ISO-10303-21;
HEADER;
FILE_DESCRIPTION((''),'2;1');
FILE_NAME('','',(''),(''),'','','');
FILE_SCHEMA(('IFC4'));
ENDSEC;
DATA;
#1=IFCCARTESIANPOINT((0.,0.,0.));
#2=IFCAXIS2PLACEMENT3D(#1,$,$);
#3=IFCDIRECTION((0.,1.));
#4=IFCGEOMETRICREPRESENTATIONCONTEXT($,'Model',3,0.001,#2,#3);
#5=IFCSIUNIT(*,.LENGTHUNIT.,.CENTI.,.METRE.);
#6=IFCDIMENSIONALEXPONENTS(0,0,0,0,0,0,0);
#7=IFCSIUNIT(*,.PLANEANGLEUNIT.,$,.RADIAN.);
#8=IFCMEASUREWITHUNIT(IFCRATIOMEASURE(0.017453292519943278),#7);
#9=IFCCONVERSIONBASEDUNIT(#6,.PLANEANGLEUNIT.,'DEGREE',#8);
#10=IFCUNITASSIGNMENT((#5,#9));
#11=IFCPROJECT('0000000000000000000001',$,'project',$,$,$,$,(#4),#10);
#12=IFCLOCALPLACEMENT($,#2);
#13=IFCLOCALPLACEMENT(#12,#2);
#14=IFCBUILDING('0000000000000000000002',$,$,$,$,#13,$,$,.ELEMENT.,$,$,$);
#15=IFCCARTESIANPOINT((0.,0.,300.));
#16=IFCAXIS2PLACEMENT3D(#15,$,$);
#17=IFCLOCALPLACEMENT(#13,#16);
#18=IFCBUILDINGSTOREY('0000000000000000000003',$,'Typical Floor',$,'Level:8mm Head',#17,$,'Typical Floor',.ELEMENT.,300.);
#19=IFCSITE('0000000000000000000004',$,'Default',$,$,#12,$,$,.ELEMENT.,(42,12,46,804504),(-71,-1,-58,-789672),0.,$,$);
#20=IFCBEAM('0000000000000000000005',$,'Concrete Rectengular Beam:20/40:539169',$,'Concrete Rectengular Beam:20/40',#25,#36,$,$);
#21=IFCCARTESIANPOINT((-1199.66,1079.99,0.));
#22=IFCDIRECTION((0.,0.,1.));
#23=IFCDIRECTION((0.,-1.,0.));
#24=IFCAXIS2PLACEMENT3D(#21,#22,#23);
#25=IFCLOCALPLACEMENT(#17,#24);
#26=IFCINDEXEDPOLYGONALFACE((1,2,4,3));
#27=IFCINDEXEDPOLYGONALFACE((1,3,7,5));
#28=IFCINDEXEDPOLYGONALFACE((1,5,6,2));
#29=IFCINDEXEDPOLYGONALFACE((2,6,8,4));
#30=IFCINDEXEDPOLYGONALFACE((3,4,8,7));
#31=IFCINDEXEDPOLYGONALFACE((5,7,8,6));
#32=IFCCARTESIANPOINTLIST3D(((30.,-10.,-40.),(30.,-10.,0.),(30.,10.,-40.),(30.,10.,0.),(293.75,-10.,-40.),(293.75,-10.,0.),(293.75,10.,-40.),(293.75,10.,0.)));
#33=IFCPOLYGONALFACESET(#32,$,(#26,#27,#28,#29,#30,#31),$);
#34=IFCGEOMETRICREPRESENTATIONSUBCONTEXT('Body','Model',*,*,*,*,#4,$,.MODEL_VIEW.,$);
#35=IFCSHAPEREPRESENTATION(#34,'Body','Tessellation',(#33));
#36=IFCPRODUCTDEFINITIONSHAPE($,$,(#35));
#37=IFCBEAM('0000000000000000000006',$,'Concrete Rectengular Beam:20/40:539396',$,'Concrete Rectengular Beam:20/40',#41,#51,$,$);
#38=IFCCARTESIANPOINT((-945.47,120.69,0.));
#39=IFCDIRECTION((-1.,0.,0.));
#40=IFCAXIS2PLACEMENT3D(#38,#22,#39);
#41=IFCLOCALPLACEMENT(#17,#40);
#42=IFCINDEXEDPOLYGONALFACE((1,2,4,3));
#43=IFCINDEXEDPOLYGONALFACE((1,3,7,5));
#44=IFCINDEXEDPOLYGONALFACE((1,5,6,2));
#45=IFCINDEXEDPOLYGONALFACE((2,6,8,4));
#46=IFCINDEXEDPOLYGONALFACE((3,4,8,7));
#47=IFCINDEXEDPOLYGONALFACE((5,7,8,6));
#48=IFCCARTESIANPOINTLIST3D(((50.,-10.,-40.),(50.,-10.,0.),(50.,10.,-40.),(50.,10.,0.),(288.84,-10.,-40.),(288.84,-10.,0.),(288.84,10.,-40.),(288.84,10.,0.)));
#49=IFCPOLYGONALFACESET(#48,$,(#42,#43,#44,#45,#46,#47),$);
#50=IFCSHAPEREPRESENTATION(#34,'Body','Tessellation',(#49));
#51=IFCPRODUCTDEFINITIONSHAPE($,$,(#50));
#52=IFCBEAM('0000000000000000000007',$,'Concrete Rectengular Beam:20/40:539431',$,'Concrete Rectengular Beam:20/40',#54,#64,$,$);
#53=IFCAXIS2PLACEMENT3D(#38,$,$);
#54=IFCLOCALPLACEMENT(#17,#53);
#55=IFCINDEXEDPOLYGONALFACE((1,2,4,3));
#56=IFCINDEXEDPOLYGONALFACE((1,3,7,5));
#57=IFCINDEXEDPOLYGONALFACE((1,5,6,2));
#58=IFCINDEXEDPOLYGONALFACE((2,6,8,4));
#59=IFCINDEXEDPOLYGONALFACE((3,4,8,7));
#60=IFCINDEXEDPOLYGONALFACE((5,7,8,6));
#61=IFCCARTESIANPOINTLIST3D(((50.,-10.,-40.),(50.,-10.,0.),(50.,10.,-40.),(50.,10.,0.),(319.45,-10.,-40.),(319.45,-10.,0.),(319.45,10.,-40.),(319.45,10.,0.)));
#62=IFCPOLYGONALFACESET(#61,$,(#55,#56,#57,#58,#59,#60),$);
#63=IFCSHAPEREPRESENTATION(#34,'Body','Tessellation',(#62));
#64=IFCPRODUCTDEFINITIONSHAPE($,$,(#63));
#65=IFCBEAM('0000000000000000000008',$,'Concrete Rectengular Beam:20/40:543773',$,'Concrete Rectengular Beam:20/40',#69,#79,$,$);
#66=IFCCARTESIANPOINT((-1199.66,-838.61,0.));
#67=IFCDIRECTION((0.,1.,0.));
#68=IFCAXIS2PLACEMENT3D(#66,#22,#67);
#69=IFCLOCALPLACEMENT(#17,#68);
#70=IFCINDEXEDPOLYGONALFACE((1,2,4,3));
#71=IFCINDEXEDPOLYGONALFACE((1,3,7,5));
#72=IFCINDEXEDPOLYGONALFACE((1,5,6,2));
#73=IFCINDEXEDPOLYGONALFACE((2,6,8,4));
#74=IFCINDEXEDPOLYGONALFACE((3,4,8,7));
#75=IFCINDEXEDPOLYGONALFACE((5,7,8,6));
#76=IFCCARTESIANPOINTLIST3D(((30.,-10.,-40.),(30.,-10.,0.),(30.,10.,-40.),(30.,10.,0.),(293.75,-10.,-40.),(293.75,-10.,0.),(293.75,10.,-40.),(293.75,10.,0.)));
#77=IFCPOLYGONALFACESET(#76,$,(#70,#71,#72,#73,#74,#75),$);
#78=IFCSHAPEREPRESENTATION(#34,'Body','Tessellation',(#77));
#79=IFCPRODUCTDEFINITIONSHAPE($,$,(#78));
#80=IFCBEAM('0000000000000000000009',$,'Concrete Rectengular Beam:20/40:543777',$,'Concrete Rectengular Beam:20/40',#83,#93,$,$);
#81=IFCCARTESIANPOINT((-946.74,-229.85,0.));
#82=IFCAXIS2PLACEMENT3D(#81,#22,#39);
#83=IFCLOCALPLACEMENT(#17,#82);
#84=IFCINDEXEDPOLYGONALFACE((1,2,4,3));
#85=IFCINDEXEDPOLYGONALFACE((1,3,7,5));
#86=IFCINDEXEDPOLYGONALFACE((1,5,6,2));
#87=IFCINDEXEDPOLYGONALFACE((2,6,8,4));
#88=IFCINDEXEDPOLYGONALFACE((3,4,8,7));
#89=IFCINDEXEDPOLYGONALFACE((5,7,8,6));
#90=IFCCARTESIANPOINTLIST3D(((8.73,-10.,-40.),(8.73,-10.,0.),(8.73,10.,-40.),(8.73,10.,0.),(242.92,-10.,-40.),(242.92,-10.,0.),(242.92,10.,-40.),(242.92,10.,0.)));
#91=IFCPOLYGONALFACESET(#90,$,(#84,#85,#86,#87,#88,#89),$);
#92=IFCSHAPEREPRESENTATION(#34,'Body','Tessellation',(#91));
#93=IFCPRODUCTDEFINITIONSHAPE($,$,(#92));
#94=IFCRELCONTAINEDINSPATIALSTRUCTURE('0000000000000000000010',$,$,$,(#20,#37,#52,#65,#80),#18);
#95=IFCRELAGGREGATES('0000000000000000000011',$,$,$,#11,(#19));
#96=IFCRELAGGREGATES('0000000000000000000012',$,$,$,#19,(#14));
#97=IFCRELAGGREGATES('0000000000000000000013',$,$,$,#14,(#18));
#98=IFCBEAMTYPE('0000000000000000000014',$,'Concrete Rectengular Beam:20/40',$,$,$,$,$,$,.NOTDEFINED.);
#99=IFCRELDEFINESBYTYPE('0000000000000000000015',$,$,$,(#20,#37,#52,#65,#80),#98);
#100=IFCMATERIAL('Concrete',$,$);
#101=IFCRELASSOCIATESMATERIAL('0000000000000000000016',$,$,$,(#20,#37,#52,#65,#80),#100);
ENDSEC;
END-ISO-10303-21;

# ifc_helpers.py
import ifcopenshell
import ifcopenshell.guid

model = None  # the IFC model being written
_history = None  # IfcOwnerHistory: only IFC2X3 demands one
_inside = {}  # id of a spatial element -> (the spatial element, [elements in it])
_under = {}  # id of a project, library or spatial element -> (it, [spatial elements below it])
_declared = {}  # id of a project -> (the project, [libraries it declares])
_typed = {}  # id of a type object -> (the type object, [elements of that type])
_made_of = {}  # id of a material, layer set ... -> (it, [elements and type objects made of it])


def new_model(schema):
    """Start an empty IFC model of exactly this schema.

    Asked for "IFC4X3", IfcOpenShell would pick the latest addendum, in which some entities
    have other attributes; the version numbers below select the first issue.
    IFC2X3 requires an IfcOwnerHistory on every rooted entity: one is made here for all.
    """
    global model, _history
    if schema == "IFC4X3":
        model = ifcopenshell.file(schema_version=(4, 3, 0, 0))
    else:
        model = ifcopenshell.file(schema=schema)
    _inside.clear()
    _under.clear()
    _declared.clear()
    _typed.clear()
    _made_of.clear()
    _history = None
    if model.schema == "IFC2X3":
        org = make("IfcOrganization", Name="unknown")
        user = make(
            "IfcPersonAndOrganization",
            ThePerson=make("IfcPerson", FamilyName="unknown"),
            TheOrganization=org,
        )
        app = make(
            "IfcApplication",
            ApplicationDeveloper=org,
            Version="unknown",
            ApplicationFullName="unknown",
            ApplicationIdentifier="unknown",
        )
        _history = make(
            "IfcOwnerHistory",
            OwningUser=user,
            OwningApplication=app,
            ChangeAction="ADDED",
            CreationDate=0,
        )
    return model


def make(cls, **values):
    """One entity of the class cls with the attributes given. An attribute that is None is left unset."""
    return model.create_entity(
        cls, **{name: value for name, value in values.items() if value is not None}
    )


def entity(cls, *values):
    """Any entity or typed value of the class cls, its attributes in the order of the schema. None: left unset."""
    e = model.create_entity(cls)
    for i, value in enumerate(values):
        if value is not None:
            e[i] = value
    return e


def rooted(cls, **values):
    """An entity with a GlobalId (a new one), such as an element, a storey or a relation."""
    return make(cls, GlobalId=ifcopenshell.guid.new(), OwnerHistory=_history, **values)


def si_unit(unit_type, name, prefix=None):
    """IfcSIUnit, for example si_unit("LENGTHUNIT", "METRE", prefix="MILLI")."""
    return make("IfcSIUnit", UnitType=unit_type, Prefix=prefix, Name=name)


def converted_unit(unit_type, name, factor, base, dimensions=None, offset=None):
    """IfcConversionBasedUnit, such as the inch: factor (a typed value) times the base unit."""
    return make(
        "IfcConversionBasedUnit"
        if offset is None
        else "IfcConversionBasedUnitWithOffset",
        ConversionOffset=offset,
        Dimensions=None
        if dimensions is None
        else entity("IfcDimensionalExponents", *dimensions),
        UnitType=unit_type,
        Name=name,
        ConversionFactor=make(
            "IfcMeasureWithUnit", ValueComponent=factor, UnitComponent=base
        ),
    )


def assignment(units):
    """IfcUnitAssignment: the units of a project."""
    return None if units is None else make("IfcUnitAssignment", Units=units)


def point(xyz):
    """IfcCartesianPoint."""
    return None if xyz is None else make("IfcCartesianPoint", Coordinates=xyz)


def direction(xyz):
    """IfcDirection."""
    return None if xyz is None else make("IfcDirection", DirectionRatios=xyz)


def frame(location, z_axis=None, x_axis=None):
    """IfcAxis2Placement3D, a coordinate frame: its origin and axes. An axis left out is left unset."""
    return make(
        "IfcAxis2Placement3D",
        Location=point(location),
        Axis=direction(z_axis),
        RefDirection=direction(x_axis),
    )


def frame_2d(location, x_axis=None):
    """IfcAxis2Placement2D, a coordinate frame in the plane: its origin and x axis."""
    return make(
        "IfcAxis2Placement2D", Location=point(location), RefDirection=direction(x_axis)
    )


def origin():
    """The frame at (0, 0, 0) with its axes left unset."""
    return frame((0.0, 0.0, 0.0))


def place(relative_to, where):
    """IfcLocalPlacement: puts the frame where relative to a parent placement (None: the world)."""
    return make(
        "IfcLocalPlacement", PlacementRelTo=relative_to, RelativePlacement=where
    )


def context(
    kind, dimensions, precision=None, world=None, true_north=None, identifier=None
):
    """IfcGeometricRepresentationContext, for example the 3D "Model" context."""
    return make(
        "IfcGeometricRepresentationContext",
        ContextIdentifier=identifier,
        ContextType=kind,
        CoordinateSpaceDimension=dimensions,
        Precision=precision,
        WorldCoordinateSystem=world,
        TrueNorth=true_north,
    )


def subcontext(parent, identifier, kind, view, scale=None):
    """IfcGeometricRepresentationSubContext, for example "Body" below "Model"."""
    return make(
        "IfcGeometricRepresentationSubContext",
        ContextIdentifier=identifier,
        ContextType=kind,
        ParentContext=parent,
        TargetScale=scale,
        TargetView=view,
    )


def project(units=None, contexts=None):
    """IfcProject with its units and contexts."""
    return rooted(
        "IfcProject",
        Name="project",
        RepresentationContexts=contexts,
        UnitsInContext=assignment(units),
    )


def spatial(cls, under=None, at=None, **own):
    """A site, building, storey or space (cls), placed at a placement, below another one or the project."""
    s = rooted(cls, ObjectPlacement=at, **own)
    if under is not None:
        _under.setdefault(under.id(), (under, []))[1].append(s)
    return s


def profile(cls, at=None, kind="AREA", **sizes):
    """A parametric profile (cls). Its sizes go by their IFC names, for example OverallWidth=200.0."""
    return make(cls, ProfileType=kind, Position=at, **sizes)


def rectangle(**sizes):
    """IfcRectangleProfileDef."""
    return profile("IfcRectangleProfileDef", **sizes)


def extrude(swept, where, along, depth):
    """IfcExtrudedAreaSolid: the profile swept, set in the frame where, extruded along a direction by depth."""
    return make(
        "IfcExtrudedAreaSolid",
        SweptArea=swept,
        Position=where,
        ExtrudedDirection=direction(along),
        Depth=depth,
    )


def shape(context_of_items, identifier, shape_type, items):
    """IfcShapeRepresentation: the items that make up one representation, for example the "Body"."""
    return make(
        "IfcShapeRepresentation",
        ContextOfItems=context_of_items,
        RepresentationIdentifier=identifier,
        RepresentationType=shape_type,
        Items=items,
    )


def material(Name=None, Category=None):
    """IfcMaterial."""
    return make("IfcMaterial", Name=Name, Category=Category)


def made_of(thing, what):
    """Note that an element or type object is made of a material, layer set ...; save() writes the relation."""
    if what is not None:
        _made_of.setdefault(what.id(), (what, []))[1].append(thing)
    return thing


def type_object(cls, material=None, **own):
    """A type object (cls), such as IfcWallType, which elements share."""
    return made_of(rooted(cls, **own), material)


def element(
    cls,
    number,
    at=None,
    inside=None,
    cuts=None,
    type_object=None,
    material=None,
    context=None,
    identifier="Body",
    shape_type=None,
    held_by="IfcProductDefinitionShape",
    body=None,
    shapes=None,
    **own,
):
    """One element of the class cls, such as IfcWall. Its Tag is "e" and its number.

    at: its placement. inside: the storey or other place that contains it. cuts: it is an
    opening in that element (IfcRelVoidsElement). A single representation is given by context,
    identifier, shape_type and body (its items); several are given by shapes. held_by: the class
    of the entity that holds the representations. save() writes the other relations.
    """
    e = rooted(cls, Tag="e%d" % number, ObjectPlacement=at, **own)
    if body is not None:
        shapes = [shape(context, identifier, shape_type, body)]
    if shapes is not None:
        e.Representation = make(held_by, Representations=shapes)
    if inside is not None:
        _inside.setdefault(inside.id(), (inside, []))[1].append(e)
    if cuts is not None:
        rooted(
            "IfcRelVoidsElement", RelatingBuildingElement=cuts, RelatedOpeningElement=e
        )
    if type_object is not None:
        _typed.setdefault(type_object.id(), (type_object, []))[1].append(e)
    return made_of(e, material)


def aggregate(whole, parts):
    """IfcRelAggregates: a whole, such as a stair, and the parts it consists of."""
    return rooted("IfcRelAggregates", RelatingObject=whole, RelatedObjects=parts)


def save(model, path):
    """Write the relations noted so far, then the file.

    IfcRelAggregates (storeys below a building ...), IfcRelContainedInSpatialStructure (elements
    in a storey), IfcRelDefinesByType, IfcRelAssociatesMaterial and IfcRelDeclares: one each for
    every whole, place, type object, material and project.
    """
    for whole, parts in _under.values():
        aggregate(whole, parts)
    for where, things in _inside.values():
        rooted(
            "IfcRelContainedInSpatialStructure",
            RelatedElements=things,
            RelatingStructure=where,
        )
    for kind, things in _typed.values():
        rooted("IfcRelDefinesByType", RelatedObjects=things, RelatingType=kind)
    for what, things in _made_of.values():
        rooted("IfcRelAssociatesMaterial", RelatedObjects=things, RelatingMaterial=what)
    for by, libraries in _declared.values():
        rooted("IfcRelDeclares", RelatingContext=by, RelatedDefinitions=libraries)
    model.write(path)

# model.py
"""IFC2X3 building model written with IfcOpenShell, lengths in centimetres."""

from ifc_helpers import new_model, entity, si_unit, converted_unit, direction, frame, frame_2d, origin, place, context, subcontext, project, spatial, rectangle, extrude, material, type_object, element, save


model = new_model("IFC2X3")

# Units and contexts
model_context = context("Model", 3, precision=0.001, world=origin(), true_north=direction((0.0, 1.0)))
body_context = subcontext(model_context, "Body", "Model", "MODEL_VIEW")
ifc_project = project(units=[si_unit("LENGTHUNIT", "METRE", prefix="CENTI"), converted_unit("PLANEANGLEUNIT", "DEGREE", entity("IfcRatioMeasure", 0.017453292519943278), si_unit("PLANEANGLEUNIT", "RADIAN"), dimensions=[0, 0, 0, 0, 0, 0, 0])], contexts=[model_context])

# Site, building, storey
site_placement = place(None, origin())
site = spatial("IfcSite", under=ifc_project, at=site_placement, Name="Default", CompositionType="ELEMENT", RefLatitude=(42, 12, 46, 804504), RefLongitude=(-71, -1, -58, -789672), RefElevation=0.0)
building_placement = place(site_placement, origin())
building = spatial("IfcBuilding", under=site, at=building_placement, CompositionType="ELEMENT")
storey_placement = place(building_placement, frame((0.0, 0.0, 300.0)))
storey = spatial("IfcBuildingStorey", under=building, at=storey_placement, Name="Typical Floor", ObjectType="Level:8mm Head", LongName="Typical Floor", CompositionType="ELEMENT", Elevation=300.0)

# Beams
ifc_material = material(Name="Concrete")
beam_type = type_object("IfcBeamType", Name="Concrete Rectengular Beam:20/40", PredefinedType="NOTDEFINED")
beam_1_placement = place(storey_placement, frame((-1199.66, 1079.99, 0.0), z_axis=(0.0, 0.0, 1.0), x_axis=(0.0, -1.0, 0.0)))
element("IfcBeam", 1, at=beam_1_placement, inside=storey, type_object=beam_type, material=ifc_material, Name="Concrete Rectengular Beam:20/40:539169", ObjectType="Concrete Rectengular Beam:20/40", context=body_context, shape_type="SweptSolid", body=[
    extrude(rectangle(XDim=40.0, YDim=20.0, at=frame_2d((0.0, 0.0), x_axis=(1.0, 0.0))), frame((30.0, 0.0, -20.0), z_axis=(1.0, 0.0, 0.0), x_axis=(0.0, 0.0, -1.0)), (0.0, 0.0, 1.0), 263.75),
])
beam_2_placement = place(storey_placement, frame((-945.47, 120.69, 0.0), z_axis=(0.0, 0.0, 1.0), x_axis=(-1.0, 0.0, 0.0)))
element("IfcBeam", 2, at=beam_2_placement, inside=storey, type_object=beam_type, material=ifc_material, Name="Concrete Rectengular Beam:20/40:539396", ObjectType="Concrete Rectengular Beam:20/40", context=body_context, shape_type="SweptSolid", body=[
    extrude(rectangle(XDim=40.0, YDim=20.0, at=frame_2d((0.0, 0.0), x_axis=(1.0, 0.0))), frame((50.0, 0.0, -20.0), z_axis=(1.0, 0.0, 0.0), x_axis=(0.0, 0.0, -1.0)), (0.0, 0.0, 1.0), 238.84),
])
beam_3_placement = place(storey_placement, frame((-945.47, 120.69, 0.0)))
element("IfcBeam", 3, at=beam_3_placement, inside=storey, type_object=beam_type, material=ifc_material, Name="Concrete Rectengular Beam:20/40:539431", ObjectType="Concrete Rectengular Beam:20/40", context=body_context, shape_type="SweptSolid", body=[
    extrude(rectangle(XDim=40.0, YDim=20.0, at=frame_2d((0.0, 0.0), x_axis=(1.0, 0.0))), frame((50.0, 0.0, -20.0), z_axis=(1.0, 0.0, 0.0), x_axis=(0.0, 0.0, -1.0)), (0.0, 0.0, 1.0), 269.45),
])
beam_4_placement = place(storey_placement, frame((-1199.66, -838.61, 0.0), z_axis=(0.0, 0.0, 1.0), x_axis=(0.0, 1.0, 0.0)))
element("IfcBeam", 4, at=beam_4_placement, inside=storey, type_object=beam_type, material=ifc_material, Name="Concrete Rectengular Beam:20/40:543773", ObjectType="Concrete Rectengular Beam:20/40", context=body_context, shape_type="SweptSolid", body=[
    extrude(rectangle(XDim=40.0, YDim=20.0, at=frame_2d((0.0, 0.0), x_axis=(1.0, 0.0))), frame((30.0, 0.0, -20.0), z_axis=(1.0, 0.0, 0.0), x_axis=(0.0, 0.0, -1.0)), (0.0, 0.0, 1.0), 263.75),
])
beam_5_placement = place(storey_placement, frame((-946.74, -229.85, 0.0), z_axis=(0.0, 0.0, 1.0), x_axis=(-1.0, 0.0, 0.0)))
element("IfcBeam", 5, at=beam_5_placement, inside=storey, type_object=beam_type, material=ifc_material, Name="Concrete Rectengular Beam:20/40:543777", ObjectType="Concrete Rectengular Beam:20/40", context=body_context, shape_type="SweptSolid", body=[
    extrude(rectangle(XDim=40.0, YDim=20.0, at=frame_2d((0.0, 0.0), x_axis=(1.0, 0.0))), frame((8.73, 0.0, -20.0), z_axis=(1.0, 0.0, 0.0), x_axis=(0.0, 0.0, -1.0)), (0.0, 0.0, 1.0), 234.19),
])

save(model, "model.ifc")
